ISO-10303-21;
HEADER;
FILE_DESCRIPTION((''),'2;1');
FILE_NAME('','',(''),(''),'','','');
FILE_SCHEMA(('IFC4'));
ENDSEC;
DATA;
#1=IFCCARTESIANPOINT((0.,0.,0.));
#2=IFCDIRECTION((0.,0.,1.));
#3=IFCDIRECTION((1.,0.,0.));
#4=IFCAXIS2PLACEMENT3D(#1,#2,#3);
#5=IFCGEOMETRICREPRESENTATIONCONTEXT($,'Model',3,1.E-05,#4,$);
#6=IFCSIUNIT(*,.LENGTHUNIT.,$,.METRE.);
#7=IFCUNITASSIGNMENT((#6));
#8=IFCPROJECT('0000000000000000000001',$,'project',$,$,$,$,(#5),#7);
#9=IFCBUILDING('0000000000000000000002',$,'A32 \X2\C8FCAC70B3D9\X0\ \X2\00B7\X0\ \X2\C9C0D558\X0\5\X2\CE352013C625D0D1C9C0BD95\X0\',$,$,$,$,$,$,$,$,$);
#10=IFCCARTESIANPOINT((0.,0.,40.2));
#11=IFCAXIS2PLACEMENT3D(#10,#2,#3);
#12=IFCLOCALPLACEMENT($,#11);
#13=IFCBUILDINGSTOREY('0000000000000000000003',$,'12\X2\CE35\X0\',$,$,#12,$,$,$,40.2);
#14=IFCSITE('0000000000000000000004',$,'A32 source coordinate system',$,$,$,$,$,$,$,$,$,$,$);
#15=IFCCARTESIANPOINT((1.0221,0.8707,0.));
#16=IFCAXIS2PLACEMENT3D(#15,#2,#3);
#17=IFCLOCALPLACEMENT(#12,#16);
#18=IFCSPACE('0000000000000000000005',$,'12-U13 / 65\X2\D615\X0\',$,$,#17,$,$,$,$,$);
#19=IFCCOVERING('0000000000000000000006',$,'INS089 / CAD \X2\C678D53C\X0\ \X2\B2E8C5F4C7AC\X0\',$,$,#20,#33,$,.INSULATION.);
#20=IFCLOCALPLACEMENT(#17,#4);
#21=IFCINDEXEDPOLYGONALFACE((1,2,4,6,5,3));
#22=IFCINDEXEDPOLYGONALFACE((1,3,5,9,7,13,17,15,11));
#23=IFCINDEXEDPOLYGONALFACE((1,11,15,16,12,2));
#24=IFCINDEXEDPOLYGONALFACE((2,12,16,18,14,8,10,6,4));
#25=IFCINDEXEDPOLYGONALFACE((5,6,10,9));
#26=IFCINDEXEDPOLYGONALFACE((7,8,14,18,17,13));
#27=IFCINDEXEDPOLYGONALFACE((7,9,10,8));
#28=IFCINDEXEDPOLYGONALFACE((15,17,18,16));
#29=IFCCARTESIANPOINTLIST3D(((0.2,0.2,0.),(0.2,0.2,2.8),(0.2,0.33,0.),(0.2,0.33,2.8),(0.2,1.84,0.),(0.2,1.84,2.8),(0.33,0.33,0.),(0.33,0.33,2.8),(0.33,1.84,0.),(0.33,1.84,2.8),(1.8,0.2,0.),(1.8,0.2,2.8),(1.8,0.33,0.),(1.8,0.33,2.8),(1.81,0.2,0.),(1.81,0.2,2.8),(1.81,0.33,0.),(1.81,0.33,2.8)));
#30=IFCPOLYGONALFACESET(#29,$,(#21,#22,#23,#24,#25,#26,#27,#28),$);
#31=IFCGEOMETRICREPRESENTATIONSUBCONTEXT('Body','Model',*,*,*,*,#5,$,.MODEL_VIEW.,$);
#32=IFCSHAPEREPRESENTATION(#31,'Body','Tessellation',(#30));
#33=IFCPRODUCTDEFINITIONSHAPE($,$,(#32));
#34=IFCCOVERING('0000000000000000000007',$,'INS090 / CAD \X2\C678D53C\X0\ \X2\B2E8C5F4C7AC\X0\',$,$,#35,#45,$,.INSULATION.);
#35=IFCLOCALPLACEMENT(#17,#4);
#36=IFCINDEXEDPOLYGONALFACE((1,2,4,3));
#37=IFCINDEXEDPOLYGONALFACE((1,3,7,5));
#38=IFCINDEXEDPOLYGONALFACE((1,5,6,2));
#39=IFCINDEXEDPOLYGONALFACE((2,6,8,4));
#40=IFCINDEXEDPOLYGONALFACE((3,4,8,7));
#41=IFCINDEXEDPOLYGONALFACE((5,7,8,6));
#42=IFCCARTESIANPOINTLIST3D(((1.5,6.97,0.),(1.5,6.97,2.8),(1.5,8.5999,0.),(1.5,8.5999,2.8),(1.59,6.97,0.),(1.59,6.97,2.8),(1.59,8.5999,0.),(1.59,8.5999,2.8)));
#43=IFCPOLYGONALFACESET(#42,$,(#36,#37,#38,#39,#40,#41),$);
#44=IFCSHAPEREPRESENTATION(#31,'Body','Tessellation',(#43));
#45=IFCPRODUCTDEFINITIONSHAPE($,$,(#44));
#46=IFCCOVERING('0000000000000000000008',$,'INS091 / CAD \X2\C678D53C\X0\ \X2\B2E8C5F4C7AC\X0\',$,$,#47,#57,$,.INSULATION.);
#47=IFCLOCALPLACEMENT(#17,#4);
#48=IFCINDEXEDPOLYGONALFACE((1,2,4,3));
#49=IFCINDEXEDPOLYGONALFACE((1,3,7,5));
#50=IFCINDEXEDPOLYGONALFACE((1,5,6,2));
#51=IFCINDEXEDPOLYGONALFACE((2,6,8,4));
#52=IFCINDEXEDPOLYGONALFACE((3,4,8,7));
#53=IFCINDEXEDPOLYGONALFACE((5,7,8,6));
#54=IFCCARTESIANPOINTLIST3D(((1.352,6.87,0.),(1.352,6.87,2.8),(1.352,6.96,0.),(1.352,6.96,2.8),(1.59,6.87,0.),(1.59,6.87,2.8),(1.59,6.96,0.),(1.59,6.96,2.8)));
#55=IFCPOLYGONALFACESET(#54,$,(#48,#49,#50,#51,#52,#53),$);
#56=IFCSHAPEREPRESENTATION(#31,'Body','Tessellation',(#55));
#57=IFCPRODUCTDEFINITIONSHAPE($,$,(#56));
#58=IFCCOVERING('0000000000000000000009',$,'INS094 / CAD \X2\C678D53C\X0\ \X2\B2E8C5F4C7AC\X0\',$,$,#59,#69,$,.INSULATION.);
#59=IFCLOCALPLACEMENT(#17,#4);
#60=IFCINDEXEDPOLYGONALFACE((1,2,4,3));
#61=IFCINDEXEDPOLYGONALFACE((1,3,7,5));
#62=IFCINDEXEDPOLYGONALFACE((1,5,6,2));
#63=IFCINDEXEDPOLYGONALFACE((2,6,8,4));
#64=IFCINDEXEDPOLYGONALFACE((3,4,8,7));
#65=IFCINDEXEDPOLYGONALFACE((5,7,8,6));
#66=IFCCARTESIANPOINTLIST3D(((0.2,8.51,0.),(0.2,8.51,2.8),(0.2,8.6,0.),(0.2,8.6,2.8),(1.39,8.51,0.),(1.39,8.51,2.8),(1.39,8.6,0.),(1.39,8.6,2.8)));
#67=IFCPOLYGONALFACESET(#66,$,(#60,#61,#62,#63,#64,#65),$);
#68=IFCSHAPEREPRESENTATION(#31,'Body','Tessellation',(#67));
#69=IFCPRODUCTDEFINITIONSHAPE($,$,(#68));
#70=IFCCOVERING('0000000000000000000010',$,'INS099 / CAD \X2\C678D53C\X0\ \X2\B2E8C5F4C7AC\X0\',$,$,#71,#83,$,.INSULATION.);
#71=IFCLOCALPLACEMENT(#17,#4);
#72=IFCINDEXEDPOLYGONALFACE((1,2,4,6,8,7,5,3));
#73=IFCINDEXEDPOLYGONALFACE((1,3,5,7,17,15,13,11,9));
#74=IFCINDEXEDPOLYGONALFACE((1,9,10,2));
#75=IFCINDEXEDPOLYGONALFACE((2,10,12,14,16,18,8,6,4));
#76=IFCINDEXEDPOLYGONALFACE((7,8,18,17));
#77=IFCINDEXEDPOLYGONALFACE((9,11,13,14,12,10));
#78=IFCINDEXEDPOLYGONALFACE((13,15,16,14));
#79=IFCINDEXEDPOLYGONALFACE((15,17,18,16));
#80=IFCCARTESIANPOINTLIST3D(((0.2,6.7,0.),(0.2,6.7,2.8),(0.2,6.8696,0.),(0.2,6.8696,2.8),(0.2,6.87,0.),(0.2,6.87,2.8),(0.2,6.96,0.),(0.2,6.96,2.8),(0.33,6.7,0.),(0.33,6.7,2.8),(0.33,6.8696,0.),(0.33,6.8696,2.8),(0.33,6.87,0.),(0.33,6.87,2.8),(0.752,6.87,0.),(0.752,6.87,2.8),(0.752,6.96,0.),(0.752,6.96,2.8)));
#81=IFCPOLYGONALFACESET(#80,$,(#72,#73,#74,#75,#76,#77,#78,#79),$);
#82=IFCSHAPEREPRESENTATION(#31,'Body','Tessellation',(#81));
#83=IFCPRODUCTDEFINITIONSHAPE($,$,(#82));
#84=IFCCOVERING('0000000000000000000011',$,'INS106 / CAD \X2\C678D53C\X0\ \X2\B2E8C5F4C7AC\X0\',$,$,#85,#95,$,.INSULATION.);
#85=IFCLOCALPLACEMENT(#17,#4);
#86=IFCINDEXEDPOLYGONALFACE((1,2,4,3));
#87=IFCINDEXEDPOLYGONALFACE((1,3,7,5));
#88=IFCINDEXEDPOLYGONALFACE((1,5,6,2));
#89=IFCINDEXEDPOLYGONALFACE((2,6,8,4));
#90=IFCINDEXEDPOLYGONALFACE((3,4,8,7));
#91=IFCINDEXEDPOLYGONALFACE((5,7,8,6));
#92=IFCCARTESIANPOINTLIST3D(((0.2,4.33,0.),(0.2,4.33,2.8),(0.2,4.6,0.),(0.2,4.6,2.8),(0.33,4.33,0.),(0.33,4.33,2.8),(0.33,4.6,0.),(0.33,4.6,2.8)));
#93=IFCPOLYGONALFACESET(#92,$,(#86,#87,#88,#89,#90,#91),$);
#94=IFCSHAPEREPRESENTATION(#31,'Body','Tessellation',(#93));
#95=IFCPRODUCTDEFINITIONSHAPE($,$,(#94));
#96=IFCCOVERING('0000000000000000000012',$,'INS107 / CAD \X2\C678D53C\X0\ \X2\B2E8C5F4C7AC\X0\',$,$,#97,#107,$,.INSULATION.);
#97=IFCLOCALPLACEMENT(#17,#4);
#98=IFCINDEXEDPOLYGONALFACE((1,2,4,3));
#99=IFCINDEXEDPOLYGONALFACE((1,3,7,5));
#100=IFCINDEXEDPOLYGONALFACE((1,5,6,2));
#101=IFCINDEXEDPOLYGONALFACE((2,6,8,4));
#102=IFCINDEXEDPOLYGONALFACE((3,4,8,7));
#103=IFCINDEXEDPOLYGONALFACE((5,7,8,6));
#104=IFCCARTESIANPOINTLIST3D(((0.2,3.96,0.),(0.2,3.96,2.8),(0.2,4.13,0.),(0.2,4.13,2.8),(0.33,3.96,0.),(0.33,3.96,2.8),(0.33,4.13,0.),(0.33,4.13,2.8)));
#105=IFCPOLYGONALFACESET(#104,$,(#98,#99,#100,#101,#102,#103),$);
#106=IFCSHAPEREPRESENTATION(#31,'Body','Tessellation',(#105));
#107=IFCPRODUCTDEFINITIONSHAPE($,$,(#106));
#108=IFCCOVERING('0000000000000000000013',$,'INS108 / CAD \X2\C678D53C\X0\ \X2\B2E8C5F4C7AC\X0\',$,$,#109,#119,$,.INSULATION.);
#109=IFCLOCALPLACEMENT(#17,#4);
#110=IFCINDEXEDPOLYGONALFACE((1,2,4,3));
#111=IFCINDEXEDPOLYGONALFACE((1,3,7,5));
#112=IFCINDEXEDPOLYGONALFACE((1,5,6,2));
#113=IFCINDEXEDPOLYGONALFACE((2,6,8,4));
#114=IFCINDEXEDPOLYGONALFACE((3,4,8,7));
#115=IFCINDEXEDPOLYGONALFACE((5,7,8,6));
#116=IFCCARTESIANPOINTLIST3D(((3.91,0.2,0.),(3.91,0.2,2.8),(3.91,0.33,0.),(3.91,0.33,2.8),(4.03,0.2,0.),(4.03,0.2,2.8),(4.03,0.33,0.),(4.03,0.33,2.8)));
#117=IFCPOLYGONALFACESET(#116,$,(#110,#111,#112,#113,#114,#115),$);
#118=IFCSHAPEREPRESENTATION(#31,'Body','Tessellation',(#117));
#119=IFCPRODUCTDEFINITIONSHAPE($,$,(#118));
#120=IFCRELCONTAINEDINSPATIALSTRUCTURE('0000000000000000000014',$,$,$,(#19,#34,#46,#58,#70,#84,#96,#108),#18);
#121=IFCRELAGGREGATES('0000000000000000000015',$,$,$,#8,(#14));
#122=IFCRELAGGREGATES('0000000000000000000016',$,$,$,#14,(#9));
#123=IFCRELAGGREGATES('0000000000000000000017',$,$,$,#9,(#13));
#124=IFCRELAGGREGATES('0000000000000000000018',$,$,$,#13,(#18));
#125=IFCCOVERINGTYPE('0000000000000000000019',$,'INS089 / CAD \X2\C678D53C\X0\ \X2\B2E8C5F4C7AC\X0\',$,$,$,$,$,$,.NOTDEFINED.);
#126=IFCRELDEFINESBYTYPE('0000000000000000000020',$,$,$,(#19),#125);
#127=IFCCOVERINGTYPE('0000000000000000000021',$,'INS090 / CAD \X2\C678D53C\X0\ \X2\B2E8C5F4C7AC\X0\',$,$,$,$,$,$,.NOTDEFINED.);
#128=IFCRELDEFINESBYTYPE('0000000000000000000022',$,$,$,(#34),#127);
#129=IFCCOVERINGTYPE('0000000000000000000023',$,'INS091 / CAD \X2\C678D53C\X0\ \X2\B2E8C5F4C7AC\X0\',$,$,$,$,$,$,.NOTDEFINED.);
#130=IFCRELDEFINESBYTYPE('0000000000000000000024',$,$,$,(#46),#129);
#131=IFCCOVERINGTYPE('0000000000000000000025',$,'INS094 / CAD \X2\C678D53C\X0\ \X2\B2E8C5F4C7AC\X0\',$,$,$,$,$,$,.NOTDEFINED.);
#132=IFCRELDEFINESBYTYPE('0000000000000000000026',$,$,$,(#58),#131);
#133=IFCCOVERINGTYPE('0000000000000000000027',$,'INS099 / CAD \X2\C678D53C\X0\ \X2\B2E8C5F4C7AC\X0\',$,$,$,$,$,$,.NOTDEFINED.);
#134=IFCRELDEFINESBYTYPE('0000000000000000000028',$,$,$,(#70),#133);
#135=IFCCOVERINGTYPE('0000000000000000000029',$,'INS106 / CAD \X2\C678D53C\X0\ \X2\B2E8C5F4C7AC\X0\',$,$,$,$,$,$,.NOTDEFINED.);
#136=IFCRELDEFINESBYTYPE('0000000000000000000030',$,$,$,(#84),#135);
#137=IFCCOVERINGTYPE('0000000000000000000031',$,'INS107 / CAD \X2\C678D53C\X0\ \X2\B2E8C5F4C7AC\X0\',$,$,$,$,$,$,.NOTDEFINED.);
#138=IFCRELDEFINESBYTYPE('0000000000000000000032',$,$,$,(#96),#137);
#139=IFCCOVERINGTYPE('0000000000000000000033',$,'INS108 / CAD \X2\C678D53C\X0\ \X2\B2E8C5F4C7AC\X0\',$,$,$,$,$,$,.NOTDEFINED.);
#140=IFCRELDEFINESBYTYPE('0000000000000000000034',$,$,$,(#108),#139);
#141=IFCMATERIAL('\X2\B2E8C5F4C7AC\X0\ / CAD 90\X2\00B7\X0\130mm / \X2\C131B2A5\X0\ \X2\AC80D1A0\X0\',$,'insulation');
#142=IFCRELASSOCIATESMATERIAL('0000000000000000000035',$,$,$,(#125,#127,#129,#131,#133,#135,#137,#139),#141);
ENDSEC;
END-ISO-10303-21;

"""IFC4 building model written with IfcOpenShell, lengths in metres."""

from ifc_helpers import new_model, si_unit, frame, origin, origin_with_axes, place, context, subcontext, project, spatial, polyline, outline, extrude, source, transform, mapped, material, type_object, type_shapes, element, save


model = new_model("IFC4")

# Units and contexts
model_context = context("Model", 3, precision=1e-05, world=origin_with_axes())
body_context = subcontext(model_context, "Body", "Model", "MODEL_VIEW")
ifc_project = project(units=[si_unit("LENGTHUNIT", "METRE")], contexts=[model_context])

# Site, building, storey
site = spatial("IfcSite", under=ifc_project, Name="A32 source coordinate system")
building = spatial("IfcBuilding", under=site, Name="A32 주거동 · 지하5층–옥탑지붕")
storey_placement = place(None, frame((0.0, 0.0, 40.2), z_axis=(0.0, 0.0, 1.0), x_axis=(1.0, 0.0, 0.0)))
storey = spatial("IfcBuildingStorey", under=building, at=storey_placement, Name="12층", Elevation=40.2)

# Shared definitions
space_placement = place(storey_placement, frame((1.0221, 0.8707, 0.0), z_axis=(0.0, 0.0, 1.0), x_axis=(1.0, 0.0, 0.0)))
space = spatial("IfcSpace", under=storey, at=space_placement, Name="12-U13 / 65형")

# Coverings
ifc_material = material(Name="단열재 / CAD 90·130mm / 성능 검토", Category="insulation")
covering_type_1 = type_object("IfcCoveringType", Name="INS089 / CAD 외피 단열재", PredefinedType="NOTDEFINED", material=ifc_material)
shared_shape_1 = source(origin(), body_context, "Body", "SweptSolid", [
    extrude(outline(polyline([(0.2, 0.33), (0.2, 1.84), (0.33, 1.84), (0.33, 0.33), (1.8, 0.33), (1.81, 0.33), (1.81, 0.2), (1.8, 0.2), (0.2, 0.2), (0.2, 0.33)])), origin(), (0.0, 0.0, 1.0), 2.8),
])
type_shapes(covering_type_1, [shared_shape_1])
covering_1_placement = place(space_placement, origin_with_axes())
element("IfcCovering", 1, at=covering_1_placement, inside=space, type_object=covering_type_1, Name="INS089 / CAD 외피 단열재", PredefinedType="INSULATION", context=body_context, shape_type="MappedRepresentation", body=[
    mapped(shared_shape_1, transform((0.0, 0.0, 0.0), scale=1.0)),
])
covering_type_2 = type_object("IfcCoveringType", Name="INS090 / CAD 외피 단열재", PredefinedType="NOTDEFINED", material=ifc_material)
shared_shape_2 = source(origin(), body_context, "Body", "SweptSolid", [
    extrude(outline(polyline([(1.59, 6.97), (1.5, 6.97), (1.5, 8.5999), (1.59, 8.5999), (1.59, 6.97)])), origin(), (0.0, 0.0, 1.0), 2.8),
])
type_shapes(covering_type_2, [shared_shape_2])
covering_2_placement = place(space_placement, origin_with_axes())
element("IfcCovering", 2, at=covering_2_placement, inside=space, type_object=covering_type_2, Name="INS090 / CAD 외피 단열재", PredefinedType="INSULATION", context=body_context, shape_type="MappedRepresentation", body=[
    mapped(shared_shape_2, transform((0.0, 0.0, 0.0), scale=1.0)),
])
covering_type_3 = type_object("IfcCoveringType", Name="INS091 / CAD 외피 단열재", PredefinedType="NOTDEFINED", material=ifc_material)
shared_shape_3 = source(origin(), body_context, "Body", "SweptSolid", [
    extrude(outline(polyline([(1.59, 6.96), (1.59, 6.87), (1.352, 6.87), (1.352, 6.96), (1.59, 6.96)])), origin(), (0.0, 0.0, 1.0), 2.8),
])
type_shapes(covering_type_3, [shared_shape_3])
covering_3_placement = place(space_placement, origin_with_axes())
element("IfcCovering", 3, at=covering_3_placement, inside=space, type_object=covering_type_3, Name="INS091 / CAD 외피 단열재", PredefinedType="INSULATION", context=body_context, shape_type="MappedRepresentation", body=[
    mapped(shared_shape_3, transform((0.0, 0.0, 0.0), scale=1.0)),
])
covering_type_4 = type_object("IfcCoveringType", Name="INS094 / CAD 외피 단열재", PredefinedType="NOTDEFINED", material=ifc_material)
shared_shape_4 = source(origin(), body_context, "Body", "SweptSolid", [
    extrude(outline(polyline([(1.39, 8.51), (0.2, 8.51), (0.2, 8.6), (1.39, 8.6), (1.39, 8.51)])), origin(), (0.0, 0.0, 1.0), 2.8),
])
type_shapes(covering_type_4, [shared_shape_4])
covering_4_placement = place(space_placement, origin_with_axes())
element("IfcCovering", 4, at=covering_4_placement, inside=space, type_object=covering_type_4, Name="INS094 / CAD 외피 단열재", PredefinedType="INSULATION", context=body_context, shape_type="MappedRepresentation", body=[
    mapped(shared_shape_4, transform((0.0, 0.0, 0.0), scale=1.0)),
])
covering_type_5 = type_object("IfcCoveringType", Name="INS099 / CAD 외피 단열재", PredefinedType="NOTDEFINED", material=ifc_material)
shared_shape_5 = source(origin(), body_context, "Body", "SweptSolid", [
    extrude(outline(polyline([(0.2, 6.8696), (0.2, 6.87), (0.2, 6.96), (0.752, 6.96), (0.752, 6.87), (0.33, 6.87), (0.33, 6.8696), (0.33, 6.7), (0.2, 6.7), (0.2, 6.8696)])), origin(), (0.0, 0.0, 1.0), 2.8),
])
type_shapes(covering_type_5, [shared_shape_5])
covering_5_placement = place(space_placement, origin_with_axes())
element("IfcCovering", 5, at=covering_5_placement, inside=space, type_object=covering_type_5, Name="INS099 / CAD 외피 단열재", PredefinedType="INSULATION", context=body_context, shape_type="MappedRepresentation", body=[
    mapped(shared_shape_5, transform((0.0, 0.0, 0.0), scale=1.0)),
])
covering_type_6 = type_object("IfcCoveringType", Name="INS106 / CAD 외피 단열재", PredefinedType="NOTDEFINED", material=ifc_material)
shared_shape_6 = source(origin(), body_context, "Body", "SweptSolid", [
    extrude(outline(polyline([(0.33, 4.6), (0.33, 4.33), (0.2, 4.33), (0.2, 4.6), (0.33, 4.6)])), origin(), (0.0, 0.0, 1.0), 2.8),
])
type_shapes(covering_type_6, [shared_shape_6])
covering_6_placement = place(space_placement, origin_with_axes())
element("IfcCovering", 6, at=covering_6_placement, inside=space, type_object=covering_type_6, Name="INS106 / CAD 외피 단열재", PredefinedType="INSULATION", context=body_context, shape_type="MappedRepresentation", body=[
    mapped(shared_shape_6, transform((0.0, 0.0, 0.0), scale=1.0)),
])
covering_type_7 = type_object("IfcCoveringType", Name="INS107 / CAD 외피 단열재", PredefinedType="NOTDEFINED", material=ifc_material)
shared_shape_7 = source(origin(), body_context, "Body", "SweptSolid", [
    extrude(outline(polyline([(0.33, 3.96), (0.2, 3.96), (0.2, 4.13), (0.33, 4.13), (0.33, 3.96)])), origin(), (0.0, 0.0, 1.0), 2.8),
])
type_shapes(covering_type_7, [shared_shape_7])
covering_7_placement = place(space_placement, origin_with_axes())
element("IfcCovering", 7, at=covering_7_placement, inside=space, type_object=covering_type_7, Name="INS107 / CAD 외피 단열재", PredefinedType="INSULATION", context=body_context, shape_type="MappedRepresentation", body=[
    mapped(shared_shape_7, transform((0.0, 0.0, 0.0), scale=1.0)),
])
covering_type_8 = type_object("IfcCoveringType", Name="INS108 / CAD 외피 단열재", PredefinedType="NOTDEFINED", material=ifc_material)
shared_shape_8 = source(origin(), body_context, "Body", "SweptSolid", [
    extrude(outline(polyline([(4.03, 0.2), (3.91, 0.2), (3.91, 0.33), (4.03, 0.33), (4.03, 0.2)])), origin(), (0.0, 0.0, 1.0), 2.8),
])
type_shapes(covering_type_8, [shared_shape_8])
covering_8_placement = place(space_placement, origin_with_axes())
element("IfcCovering", 8, at=covering_8_placement, inside=space, type_object=covering_type_8, Name="INS108 / CAD 외피 단열재", PredefinedType="INSULATION", context=body_context, shape_type="MappedRepresentation", body=[
    mapped(shared_shape_8, transform((0.0, 0.0, 0.0), scale=1.0)),
])

save(model, "model.ifc")
